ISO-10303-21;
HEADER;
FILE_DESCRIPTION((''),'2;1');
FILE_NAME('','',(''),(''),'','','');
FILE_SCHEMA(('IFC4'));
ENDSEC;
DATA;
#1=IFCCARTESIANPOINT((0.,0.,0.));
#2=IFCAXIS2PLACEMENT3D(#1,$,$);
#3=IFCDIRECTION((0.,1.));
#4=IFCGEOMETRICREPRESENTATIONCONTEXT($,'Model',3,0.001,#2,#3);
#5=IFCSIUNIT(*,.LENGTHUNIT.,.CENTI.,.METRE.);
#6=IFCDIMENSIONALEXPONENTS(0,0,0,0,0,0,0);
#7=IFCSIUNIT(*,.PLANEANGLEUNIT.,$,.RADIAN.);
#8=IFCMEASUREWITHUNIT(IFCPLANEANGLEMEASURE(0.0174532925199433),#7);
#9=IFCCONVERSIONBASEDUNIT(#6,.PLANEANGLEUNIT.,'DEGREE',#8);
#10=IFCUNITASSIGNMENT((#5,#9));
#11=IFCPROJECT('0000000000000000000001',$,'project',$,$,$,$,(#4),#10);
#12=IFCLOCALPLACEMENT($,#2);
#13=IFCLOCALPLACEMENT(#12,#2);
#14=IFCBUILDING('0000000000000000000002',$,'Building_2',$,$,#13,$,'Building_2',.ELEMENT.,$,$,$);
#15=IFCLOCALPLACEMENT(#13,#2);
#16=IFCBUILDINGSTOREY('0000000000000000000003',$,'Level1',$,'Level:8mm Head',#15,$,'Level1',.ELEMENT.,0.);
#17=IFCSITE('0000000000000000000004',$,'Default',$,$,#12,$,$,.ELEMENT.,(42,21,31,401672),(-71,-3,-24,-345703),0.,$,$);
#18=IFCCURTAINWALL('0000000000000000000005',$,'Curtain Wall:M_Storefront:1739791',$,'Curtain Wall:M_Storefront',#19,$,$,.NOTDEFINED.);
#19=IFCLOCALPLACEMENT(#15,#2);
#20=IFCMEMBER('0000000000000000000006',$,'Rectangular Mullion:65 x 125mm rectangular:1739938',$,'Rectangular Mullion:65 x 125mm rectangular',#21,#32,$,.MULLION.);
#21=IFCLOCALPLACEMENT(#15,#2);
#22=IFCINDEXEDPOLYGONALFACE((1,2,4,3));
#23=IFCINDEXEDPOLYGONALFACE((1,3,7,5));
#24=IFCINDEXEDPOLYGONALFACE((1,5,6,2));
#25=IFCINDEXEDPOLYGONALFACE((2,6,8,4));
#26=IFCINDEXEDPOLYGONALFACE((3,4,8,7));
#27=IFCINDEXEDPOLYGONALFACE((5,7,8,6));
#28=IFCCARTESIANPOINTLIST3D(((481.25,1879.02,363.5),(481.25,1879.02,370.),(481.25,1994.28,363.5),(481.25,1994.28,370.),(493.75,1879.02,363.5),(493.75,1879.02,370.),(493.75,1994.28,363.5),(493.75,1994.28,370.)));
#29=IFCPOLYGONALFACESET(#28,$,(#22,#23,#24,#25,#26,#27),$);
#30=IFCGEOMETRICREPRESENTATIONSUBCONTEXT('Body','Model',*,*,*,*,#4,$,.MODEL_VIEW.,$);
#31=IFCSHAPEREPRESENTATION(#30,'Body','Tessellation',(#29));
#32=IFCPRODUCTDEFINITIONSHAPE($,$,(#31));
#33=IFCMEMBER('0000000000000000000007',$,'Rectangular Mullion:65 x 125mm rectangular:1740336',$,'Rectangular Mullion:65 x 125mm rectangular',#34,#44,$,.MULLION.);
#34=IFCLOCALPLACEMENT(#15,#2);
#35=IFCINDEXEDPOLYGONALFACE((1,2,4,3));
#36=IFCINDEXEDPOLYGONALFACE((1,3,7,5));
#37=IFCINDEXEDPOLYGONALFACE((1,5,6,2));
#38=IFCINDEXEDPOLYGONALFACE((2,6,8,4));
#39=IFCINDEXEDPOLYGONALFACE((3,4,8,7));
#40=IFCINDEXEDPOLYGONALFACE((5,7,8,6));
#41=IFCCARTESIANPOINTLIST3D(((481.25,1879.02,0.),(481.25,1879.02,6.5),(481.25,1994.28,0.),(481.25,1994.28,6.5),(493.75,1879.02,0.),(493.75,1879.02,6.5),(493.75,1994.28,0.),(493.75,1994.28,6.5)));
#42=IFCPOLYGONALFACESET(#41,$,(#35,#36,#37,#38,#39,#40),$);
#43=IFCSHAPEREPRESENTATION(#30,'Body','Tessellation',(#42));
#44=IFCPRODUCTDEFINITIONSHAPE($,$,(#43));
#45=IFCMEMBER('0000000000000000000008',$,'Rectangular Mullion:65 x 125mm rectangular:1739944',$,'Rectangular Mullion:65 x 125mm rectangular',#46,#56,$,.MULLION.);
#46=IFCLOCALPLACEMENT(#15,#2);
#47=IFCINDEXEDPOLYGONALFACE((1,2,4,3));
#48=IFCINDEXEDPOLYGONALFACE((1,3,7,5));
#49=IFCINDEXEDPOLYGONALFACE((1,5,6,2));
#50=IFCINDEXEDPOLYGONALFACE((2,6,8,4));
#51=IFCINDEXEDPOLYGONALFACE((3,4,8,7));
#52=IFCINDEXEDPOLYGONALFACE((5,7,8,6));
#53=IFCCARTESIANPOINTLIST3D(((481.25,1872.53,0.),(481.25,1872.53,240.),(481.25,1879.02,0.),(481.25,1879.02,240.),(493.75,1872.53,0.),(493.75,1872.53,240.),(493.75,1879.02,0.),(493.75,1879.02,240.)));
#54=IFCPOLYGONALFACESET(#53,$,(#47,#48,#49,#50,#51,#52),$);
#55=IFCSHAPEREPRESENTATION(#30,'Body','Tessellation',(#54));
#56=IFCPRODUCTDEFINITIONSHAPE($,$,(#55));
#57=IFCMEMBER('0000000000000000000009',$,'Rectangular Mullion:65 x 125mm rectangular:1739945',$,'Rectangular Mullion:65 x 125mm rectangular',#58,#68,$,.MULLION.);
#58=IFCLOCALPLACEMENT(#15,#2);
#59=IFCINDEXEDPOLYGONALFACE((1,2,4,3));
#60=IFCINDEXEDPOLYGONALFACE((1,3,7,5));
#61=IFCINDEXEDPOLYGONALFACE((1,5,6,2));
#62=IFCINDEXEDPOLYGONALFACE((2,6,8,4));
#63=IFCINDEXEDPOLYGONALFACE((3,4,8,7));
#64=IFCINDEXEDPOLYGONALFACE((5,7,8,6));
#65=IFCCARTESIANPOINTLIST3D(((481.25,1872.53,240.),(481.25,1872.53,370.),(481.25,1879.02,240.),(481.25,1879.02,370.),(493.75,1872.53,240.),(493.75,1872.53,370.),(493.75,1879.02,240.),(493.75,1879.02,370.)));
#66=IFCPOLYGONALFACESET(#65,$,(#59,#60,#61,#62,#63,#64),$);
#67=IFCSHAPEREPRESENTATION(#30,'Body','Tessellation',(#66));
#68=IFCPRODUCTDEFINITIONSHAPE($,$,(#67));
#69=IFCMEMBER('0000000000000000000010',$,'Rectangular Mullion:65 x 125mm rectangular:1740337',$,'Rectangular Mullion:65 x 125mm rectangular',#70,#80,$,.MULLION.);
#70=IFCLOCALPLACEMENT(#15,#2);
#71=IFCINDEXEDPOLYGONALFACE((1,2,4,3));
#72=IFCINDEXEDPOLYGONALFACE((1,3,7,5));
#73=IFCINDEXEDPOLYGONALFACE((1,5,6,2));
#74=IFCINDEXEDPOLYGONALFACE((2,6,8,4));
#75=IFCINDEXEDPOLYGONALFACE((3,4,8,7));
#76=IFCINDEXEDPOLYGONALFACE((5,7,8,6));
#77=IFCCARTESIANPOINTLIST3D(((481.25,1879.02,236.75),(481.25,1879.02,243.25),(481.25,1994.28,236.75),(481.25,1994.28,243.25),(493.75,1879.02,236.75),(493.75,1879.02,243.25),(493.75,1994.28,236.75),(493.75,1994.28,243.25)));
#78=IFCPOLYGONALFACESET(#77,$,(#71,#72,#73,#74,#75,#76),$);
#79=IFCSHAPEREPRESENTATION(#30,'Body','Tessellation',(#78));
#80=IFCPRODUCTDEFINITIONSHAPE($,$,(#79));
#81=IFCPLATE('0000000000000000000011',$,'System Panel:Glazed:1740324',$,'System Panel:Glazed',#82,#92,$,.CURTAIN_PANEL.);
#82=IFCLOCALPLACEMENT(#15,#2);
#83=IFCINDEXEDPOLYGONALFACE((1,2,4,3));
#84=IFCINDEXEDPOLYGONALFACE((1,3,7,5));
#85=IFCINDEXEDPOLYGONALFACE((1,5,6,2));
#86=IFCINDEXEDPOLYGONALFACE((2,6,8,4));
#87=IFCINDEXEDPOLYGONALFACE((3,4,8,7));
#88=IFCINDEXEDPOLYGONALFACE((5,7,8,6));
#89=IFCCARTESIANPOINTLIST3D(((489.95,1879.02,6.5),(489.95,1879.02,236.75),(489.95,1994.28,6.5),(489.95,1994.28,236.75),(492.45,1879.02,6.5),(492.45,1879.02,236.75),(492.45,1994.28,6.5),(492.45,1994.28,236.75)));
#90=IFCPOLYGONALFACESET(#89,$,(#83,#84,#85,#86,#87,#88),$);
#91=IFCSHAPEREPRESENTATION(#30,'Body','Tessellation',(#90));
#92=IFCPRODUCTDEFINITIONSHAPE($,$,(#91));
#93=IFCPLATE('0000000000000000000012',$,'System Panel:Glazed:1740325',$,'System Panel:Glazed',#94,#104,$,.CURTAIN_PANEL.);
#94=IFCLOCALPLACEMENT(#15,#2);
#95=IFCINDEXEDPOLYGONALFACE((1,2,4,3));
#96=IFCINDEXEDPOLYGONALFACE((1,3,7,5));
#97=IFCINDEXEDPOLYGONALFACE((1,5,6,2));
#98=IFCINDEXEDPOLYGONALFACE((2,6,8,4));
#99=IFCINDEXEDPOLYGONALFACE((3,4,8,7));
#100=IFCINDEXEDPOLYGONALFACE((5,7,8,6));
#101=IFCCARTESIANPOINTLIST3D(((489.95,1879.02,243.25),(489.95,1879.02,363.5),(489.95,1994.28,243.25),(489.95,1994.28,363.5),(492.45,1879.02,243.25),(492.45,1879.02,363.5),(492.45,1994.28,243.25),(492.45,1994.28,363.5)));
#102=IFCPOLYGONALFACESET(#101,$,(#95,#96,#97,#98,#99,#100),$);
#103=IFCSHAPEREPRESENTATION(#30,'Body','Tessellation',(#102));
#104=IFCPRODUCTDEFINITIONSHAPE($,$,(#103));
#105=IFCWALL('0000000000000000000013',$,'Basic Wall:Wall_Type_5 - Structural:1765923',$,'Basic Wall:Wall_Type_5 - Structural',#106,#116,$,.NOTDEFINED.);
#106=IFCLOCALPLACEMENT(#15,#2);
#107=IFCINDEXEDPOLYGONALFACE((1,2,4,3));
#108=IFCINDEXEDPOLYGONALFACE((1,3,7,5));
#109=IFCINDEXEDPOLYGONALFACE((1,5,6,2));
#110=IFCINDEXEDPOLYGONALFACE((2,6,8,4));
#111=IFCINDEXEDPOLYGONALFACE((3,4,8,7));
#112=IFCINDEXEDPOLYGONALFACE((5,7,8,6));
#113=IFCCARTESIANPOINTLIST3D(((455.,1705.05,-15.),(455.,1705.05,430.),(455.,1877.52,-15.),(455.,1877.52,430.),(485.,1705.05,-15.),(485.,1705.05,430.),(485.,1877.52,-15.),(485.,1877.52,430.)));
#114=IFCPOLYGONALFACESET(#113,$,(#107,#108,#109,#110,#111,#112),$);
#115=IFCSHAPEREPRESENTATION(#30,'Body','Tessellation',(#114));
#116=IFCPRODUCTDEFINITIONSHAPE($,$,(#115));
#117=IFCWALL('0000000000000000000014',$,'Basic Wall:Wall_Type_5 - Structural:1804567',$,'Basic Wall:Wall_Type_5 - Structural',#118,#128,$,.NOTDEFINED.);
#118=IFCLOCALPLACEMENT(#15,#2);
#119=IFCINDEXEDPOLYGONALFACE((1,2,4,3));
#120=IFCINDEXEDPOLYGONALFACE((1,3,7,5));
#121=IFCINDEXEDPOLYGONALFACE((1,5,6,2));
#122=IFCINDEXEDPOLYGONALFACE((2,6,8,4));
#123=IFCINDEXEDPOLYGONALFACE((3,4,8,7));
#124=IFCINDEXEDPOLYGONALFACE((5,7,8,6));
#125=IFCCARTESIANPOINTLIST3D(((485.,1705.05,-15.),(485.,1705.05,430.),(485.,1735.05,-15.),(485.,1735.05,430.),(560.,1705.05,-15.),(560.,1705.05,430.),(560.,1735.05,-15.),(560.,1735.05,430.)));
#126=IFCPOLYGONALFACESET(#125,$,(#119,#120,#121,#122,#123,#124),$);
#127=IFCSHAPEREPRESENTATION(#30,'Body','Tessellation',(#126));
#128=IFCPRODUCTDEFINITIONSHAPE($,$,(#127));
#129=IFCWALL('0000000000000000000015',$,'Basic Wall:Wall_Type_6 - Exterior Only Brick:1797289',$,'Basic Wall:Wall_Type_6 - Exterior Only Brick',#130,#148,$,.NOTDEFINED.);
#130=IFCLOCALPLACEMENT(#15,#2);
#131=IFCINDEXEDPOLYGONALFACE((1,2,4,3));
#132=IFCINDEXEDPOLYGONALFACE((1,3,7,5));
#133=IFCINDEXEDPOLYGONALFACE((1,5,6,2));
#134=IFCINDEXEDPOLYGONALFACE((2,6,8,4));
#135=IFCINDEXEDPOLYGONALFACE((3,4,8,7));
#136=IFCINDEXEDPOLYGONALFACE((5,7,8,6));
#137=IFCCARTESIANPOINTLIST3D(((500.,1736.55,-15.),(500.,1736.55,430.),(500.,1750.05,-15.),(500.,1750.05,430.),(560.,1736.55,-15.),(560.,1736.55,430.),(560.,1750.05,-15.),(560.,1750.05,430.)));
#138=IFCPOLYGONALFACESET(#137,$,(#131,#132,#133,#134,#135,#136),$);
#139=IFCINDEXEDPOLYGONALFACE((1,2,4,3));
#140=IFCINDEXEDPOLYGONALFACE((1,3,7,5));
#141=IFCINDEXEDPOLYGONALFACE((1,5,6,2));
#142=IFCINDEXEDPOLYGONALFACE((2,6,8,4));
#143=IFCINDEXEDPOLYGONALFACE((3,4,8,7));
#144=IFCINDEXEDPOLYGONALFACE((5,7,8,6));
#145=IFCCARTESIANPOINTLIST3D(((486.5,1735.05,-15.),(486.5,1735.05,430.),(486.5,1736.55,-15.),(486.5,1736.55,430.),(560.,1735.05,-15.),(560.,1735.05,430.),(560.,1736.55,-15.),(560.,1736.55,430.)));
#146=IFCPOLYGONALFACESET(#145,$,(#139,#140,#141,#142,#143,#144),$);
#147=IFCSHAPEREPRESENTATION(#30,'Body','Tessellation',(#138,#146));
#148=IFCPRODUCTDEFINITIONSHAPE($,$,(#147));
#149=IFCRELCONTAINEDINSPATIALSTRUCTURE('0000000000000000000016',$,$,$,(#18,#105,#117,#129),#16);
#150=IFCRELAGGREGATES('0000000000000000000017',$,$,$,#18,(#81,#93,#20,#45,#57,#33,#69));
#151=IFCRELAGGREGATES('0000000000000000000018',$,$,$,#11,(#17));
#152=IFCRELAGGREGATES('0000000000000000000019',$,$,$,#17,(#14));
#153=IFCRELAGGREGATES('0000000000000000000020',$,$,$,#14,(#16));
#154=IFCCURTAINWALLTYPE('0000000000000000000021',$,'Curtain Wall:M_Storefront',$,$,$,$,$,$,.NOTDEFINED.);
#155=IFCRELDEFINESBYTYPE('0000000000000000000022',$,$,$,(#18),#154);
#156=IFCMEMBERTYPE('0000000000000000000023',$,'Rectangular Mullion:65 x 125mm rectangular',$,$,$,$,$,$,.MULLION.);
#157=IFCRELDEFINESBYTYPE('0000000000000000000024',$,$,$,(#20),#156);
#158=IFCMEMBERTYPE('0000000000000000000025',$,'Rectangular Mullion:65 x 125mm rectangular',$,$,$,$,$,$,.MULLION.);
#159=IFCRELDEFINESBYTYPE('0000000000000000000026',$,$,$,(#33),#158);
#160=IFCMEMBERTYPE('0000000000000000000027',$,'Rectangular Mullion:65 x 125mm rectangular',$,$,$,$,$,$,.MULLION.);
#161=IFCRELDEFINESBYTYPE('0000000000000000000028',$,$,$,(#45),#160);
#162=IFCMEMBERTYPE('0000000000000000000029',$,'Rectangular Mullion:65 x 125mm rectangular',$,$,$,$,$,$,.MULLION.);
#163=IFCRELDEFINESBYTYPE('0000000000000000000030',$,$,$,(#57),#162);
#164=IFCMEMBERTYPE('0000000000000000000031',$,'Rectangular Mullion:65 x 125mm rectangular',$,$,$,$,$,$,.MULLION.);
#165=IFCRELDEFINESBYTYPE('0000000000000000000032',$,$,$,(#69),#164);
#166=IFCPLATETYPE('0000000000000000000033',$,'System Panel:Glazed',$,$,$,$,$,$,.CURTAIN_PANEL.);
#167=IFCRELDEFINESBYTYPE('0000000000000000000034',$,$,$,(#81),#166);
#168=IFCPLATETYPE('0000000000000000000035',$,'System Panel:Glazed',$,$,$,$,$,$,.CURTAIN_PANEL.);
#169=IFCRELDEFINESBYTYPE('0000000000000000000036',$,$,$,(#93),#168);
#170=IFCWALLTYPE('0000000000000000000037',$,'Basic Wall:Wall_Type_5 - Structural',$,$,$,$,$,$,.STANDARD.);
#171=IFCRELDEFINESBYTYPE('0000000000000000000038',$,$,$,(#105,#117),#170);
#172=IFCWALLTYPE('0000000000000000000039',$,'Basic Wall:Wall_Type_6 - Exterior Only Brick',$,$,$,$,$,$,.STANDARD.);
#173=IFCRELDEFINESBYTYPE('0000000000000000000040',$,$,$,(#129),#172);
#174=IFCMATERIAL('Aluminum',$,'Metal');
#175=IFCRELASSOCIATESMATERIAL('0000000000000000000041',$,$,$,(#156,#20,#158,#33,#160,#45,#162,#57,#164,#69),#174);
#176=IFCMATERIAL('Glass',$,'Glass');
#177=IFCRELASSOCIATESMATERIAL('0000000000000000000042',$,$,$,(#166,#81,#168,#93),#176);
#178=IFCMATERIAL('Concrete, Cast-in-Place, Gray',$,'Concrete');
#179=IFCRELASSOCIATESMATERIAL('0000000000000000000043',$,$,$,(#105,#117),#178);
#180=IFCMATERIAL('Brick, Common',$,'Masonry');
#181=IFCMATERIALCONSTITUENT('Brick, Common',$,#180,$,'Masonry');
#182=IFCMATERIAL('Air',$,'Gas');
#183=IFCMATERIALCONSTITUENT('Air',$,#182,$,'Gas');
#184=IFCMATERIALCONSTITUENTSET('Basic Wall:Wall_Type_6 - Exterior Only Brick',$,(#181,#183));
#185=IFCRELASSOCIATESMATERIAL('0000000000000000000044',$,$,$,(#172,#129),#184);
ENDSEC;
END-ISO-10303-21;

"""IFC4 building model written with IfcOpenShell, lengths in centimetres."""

from ifc_helpers import new_model, entity, si_unit, converted_unit, direction, frame, origin, place, context, subcontext, project, spatial, indexed_curve, outline, extrude, source, transform, mapped, material, constituent, constituent_set, type_object, type_shapes, element, aggregate, save


model = new_model("IFC4")

# Units and contexts
model_context = context("Model", 3, precision=0.001, world=origin(), true_north=direction((0.0, 1.0)))
body_context = subcontext(model_context, "Body", "Model", "MODEL_VIEW")
ifc_project = project(units=[si_unit("LENGTHUNIT", "METRE", prefix="CENTI"), converted_unit("PLANEANGLEUNIT", "DEGREE", entity("IfcPlaneAngleMeasure", 0.0174532925199433), si_unit("PLANEANGLEUNIT", "RADIAN"), dimensions=[0, 0, 0, 0, 0, 0, 0])], contexts=[model_context])

# Site, building, storey
site_placement = place(None, origin())
site = spatial("IfcSite", under=ifc_project, at=site_placement, Name="Default", CompositionType="ELEMENT", RefLatitude=(42, 21, 31, 401672), RefLongitude=(-71, -3, -24, -345703), RefElevation=0.0)
building_placement = place(site_placement, origin())
building = spatial("IfcBuilding", under=site, at=building_placement, Name="Building_2", LongName="Building_2", CompositionType="ELEMENT")
storey_placement = place(building_placement, origin())
storey = spatial("IfcBuildingStorey", under=building, at=storey_placement, Name="Level1", ObjectType="Level:8mm Head", LongName="Level1", CompositionType="ELEMENT", Elevation=0.0)

# Curtain wall, members, plates
curtain_wall_type = type_object("IfcCurtainWallType", Name="Curtain Wall:M_Storefront", PredefinedType="NOTDEFINED")
curtain_wall_placement = place(storey_placement, origin())
curtain_wall = element("IfcCurtainWall", 1, at=curtain_wall_placement, inside=storey, type_object=curtain_wall_type, Name="Curtain Wall:M_Storefront:1739791", ObjectType="Curtain Wall:M_Storefront", PredefinedType="NOTDEFINED")
ifc_material_1 = material(Name="Aluminum", Category="Metal")
member_type_1 = type_object("IfcMemberType", Name="Rectangular Mullion:65 x 125mm rectangular", PredefinedType="MULLION", material=ifc_material_1)
shared_shape_1 = source(origin(), body_context, "Body", "SweptSolid", [
    extrude(outline(indexed_curve([(-3.25, -6.25), (3.25, -6.25), (3.25, 6.25), (-3.25, 6.25), (-3.25, -6.25)], self_intersect=False)), frame((-3.25, 0.0, -115.25), z_axis=(0.0, 0.0, 1.0), x_axis=(-1.0, 0.0, 0.0)), (0.0, 0.0, 1.0), 115.25),
])
type_shapes(member_type_1, [shared_shape_1])
member_1_placement = place(curtain_wall_placement, frame((487.5, 1879.03, 370.0), z_axis=(0.0, -1.0, 0.0), x_axis=(0.0, 0.0, 1.0)))
member_1 = element("IfcMember", 2, at=member_1_placement, type_object=member_type_1, material=ifc_material_1, Name="Rectangular Mullion:65 x 125mm rectangular:1739938", ObjectType="Rectangular Mullion:65 x 125mm rectangular", PredefinedType="MULLION", context=body_context, shape_type="MappedRepresentation", body=[
    mapped(shared_shape_1, transform((0.0, 0.0, 0.0), scale=1.0)),
])
member_type_2 = type_object("IfcMemberType", Name="Rectangular Mullion:65 x 125mm rectangular", PredefinedType="MULLION", material=ifc_material_1)
shared_shape_2 = source(origin(), body_context, "Body", "SweptSolid", [
    extrude(outline(indexed_curve([(-3.25, -6.25), (3.25, -6.25), (3.25, 6.25), (-3.25, 6.25), (-3.25, -6.25)], self_intersect=False)), frame((-3.25, 0.0, -115.25), z_axis=(0.0, 0.0, 1.0), x_axis=(-1.0, 0.0, 0.0)), (0.0, 0.0, 1.0), 115.25),
])
type_shapes(member_type_2, [shared_shape_2])
member_2_placement = place(curtain_wall_placement, frame((487.5, 1994.28, 0.0), z_axis=(0.0, 1.0, 0.0), x_axis=(0.0, 0.0, -1.0)))
member_2 = element("IfcMember", 3, at=member_2_placement, type_object=member_type_2, material=ifc_material_1, Name="Rectangular Mullion:65 x 125mm rectangular:1740336", ObjectType="Rectangular Mullion:65 x 125mm rectangular", PredefinedType="MULLION", context=body_context, shape_type="MappedRepresentation", body=[
    mapped(shared_shape_2, transform((0.0, 0.0, 0.0), scale=1.0)),
])
member_type_3 = type_object("IfcMemberType", Name="Rectangular Mullion:65 x 125mm rectangular", PredefinedType="MULLION", material=ifc_material_1)
shared_shape_3 = source(origin(), body_context, "Body", "SweptSolid", [
    extrude(outline(indexed_curve([(-3.25, -6.25), (3.25, -6.25), (3.25, 6.25), (-3.25, 6.25), (-3.25, -6.25)], self_intersect=False)), frame((-3.25, 0.0, -240.0), z_axis=(0.0, 0.0, 1.0), x_axis=(-1.0, 0.0, 0.0)), (0.0, 0.0, 1.0), 240.0),
])
type_shapes(member_type_3, [shared_shape_3])
member_3_placement = place(curtain_wall_placement, frame((487.5, 1872.53, 0.0), z_axis=(0.0, 0.0, -1.0), x_axis=(0.0, -1.0, 0.0)))
member_3 = element("IfcMember", 4, at=member_3_placement, type_object=member_type_3, material=ifc_material_1, Name="Rectangular Mullion:65 x 125mm rectangular:1739944", ObjectType="Rectangular Mullion:65 x 125mm rectangular", PredefinedType="MULLION", context=body_context, shape_type="MappedRepresentation", body=[
    mapped(shared_shape_3, transform((0.0, 0.0, 0.0), scale=1.0)),
])
member_type_4 = type_object("IfcMemberType", Name="Rectangular Mullion:65 x 125mm rectangular", PredefinedType="MULLION", material=ifc_material_1)
shared_shape_4 = source(origin(), body_context, "Body", "SweptSolid", [
    extrude(outline(indexed_curve([(-3.25, -6.25), (3.25, -6.25), (3.25, 6.25), (-3.25, 6.25), (-3.25, -6.25)], self_intersect=False)), frame((-3.25, 0.0, -130.0), z_axis=(0.0, 0.0, 1.0), x_axis=(-1.0, 0.0, 0.0)), (0.0, 0.0, 1.0), 130.0),
])
type_shapes(member_type_4, [shared_shape_4])
member_4_placement = place(curtain_wall_placement, frame((487.5, 1872.53, 240.0), z_axis=(0.0, 0.0, -1.0), x_axis=(0.0, -1.0, 0.0)))
member_4 = element("IfcMember", 5, at=member_4_placement, type_object=member_type_4, material=ifc_material_1, Name="Rectangular Mullion:65 x 125mm rectangular:1739945", ObjectType="Rectangular Mullion:65 x 125mm rectangular", PredefinedType="MULLION", context=body_context, shape_type="MappedRepresentation", body=[
    mapped(shared_shape_4, transform((0.0, 0.0, 0.0), scale=1.0)),
])
member_type_5 = type_object("IfcMemberType", Name="Rectangular Mullion:65 x 125mm rectangular", PredefinedType="MULLION", material=ifc_material_1)
shared_shape_5 = source(origin(), body_context, "Body", "SweptSolid", [
    extrude(outline(indexed_curve([(-3.25, -6.25), (3.25, -6.25), (3.25, 6.25), (-3.25, 6.25), (-3.25, -6.25)], self_intersect=False)), frame((0.0, 0.0, -115.25), z_axis=(0.0, 0.0, 1.0), x_axis=(-1.0, 0.0, 0.0)), (0.0, 0.0, 1.0), 115.25),
])
type_shapes(member_type_5, [shared_shape_5])
member_5_placement = place(curtain_wall_placement, frame((487.5, 1879.03, 240.0), z_axis=(0.0, -1.0, 0.0), x_axis=(0.0, 0.0, 1.0)))
member_5 = element("IfcMember", 6, at=member_5_placement, type_object=member_type_5, material=ifc_material_1, Name="Rectangular Mullion:65 x 125mm rectangular:1740337", ObjectType="Rectangular Mullion:65 x 125mm rectangular", PredefinedType="MULLION", context=body_context, shape_type="MappedRepresentation", body=[
    mapped(shared_shape_5, transform((0.0, 0.0, 0.0), scale=1.0)),
])
ifc_material_2 = material(Name="Glass", Category="Glass")
plate_type_1 = type_object("IfcPlateType", Name="System Panel:Glazed", PredefinedType="CURTAIN_PANEL", material=ifc_material_2)
shared_shape_6 = source(origin(), body_context, "Body", "SweptSolid", [
    extrude(outline(indexed_curve([(-1.25, -57.63), (1.25, -57.63), (1.25, 57.63), (-1.25, 57.63), (-1.25, -57.63)], self_intersect=False)), frame((0.0, 3.7, 0.0), z_axis=(0.0, 0.0, 1.0), x_axis=(0.0, 1.0, 0.0)), (0.0, 0.0, 1.0), 230.25),
])
type_shapes(plate_type_1, [shared_shape_6])
plate_1_placement = place(curtain_wall_placement, frame((487.5, 1936.65, 6.5), z_axis=(0.0, 0.0, 1.0), x_axis=(0.0, -1.0, 0.0)))
plate_1 = element("IfcPlate", 7, at=plate_1_placement, type_object=plate_type_1, material=ifc_material_2, Name="System Panel:Glazed:1740324", ObjectType="System Panel:Glazed", PredefinedType="CURTAIN_PANEL", context=body_context, shape_type="MappedRepresentation", body=[
    mapped(shared_shape_6, transform((0.0, 0.0, 0.0), scale=1.0)),
])
plate_type_2 = type_object("IfcPlateType", Name="System Panel:Glazed", PredefinedType="CURTAIN_PANEL", material=ifc_material_2)
shared_shape_7 = source(origin(), body_context, "Body", "SweptSolid", [
    extrude(outline(indexed_curve([(-1.25, -57.63), (1.25, -57.63), (1.25, 57.63), (-1.25, 57.63), (-1.25, -57.63)], self_intersect=False)), frame((0.0, 3.7, 0.0), z_axis=(0.0, 0.0, 1.0), x_axis=(0.0, 1.0, 0.0)), (0.0, 0.0, 1.0), 120.25),
])
type_shapes(plate_type_2, [shared_shape_7])
plate_2_placement = place(curtain_wall_placement, frame((487.5, 1936.65, 243.25), z_axis=(0.0, 0.0, 1.0), x_axis=(0.0, -1.0, 0.0)))
plate_2 = element("IfcPlate", 8, at=plate_2_placement, type_object=plate_type_2, material=ifc_material_2, Name="System Panel:Glazed:1740325", ObjectType="System Panel:Glazed", PredefinedType="CURTAIN_PANEL", context=body_context, shape_type="MappedRepresentation", body=[
    mapped(shared_shape_7, transform((0.0, 0.0, 0.0), scale=1.0)),
])
aggregate(curtain_wall, [plate_1, plate_2, member_1, member_3, member_4, member_2, member_5])

# Shared definitions
ifc_material_3 = material(Name="Brick, Common", Category="Masonry")
ifc_material_4 = material(Name="Air", Category="Gas")

# Walls
ifc_material_5 = material(Name="Concrete, Cast-in-Place, Gray", Category="Concrete")
wall_type_1 = type_object("IfcWallType", Name="Basic Wall:Wall_Type_5 - Structural", PredefinedType="STANDARD")
wall_1_placement = place(storey_placement, frame((470.0, 1877.53, -15.0), z_axis=(0.0, 0.0, 1.0), x_axis=(0.0, -1.0, 0.0)))
element("IfcWall", 9, at=wall_1_placement, inside=storey, type_object=wall_type_1, material=ifc_material_5, Name="Basic Wall:Wall_Type_5 - Structural:1765923", ObjectType="Basic Wall:Wall_Type_5 - Structural", PredefinedType="NOTDEFINED", context=body_context, shape_type="SweptSolid", body=[
    extrude(outline(indexed_curve([(172.47, 15.0), (0.0, 15.0), (0.0, -15.0), (172.47, -15.0), (172.47, 15.0)], self_intersect=False)), origin(), (0.0, 0.0, 1.0), 445.0),
])
wall_2_placement = place(storey_placement, frame((485.0, 1720.05, -15.0)))
element("IfcWall", 10, at=wall_2_placement, inside=storey, type_object=wall_type_1, material=ifc_material_5, Name="Basic Wall:Wall_Type_5 - Structural:1804567", ObjectType="Basic Wall:Wall_Type_5 - Structural", PredefinedType="NOTDEFINED", context=body_context, shape_type="SweptSolid", body=[
    extrude(outline(indexed_curve([(75.0, 15.0), (0.0, 15.0), (0.0, -15.0), (75.0, -15.0), (75.0, 15.0)], self_intersect=False)), origin(), (0.0, 0.0, 1.0), 445.0),
])

# Shared definitions
ifc_constituent_1 = constituent(ifc_material_3, Name="Brick, Common", Category="Masonry")
ifc_constituent_2 = constituent(ifc_material_4, Name="Air", Category="Gas")
ifc_constituent_set_1 = constituent_set(constituents=[ifc_constituent_1, ifc_constituent_2], Name="Basic Wall:Wall_Type_6 - Exterior Only Brick")
wall_type_2 = type_object("IfcWallType", Name="Basic Wall:Wall_Type_6 - Exterior Only Brick", PredefinedType="STANDARD", material=ifc_constituent_set_1)

# Wall
wall_3_placement = place(storey_placement, frame((500.0, 1742.55, -15.0)))
element("IfcWall", 11, at=wall_3_placement, inside=storey, type_object=wall_type_2, material=ifc_constituent_set_1, Name="Basic Wall:Wall_Type_6 - Exterior Only Brick:1797289", ObjectType="Basic Wall:Wall_Type_6 - Exterior Only Brick", PredefinedType="NOTDEFINED", context=body_context, shape_type="SweptSolid", body=[
    extrude(outline(indexed_curve([(-6.75, -30.0), (6.75, -30.0), (6.75, 30.0), (-6.75, 30.0), (-6.75, -30.0)], self_intersect=False)), frame((30.0, 0.75, 0.0), z_axis=(0.0, 0.0, 1.0), x_axis=(0.0, -1.0, 0.0)), (0.0, 0.0, 1.0), 445.0),
    extrude(outline(indexed_curve([(-0.75, -36.75), (0.75, -36.75), (0.75, 36.75), (-0.75, 36.75), (-0.75, -36.75)], self_intersect=False)), frame((23.25, -6.75, 0.0), z_axis=(0.0, 0.0, 1.0), x_axis=(0.0, 1.0, 0.0)), (0.0, 0.0, 1.0), 445.0),
])

save(model, "model.ifc")
